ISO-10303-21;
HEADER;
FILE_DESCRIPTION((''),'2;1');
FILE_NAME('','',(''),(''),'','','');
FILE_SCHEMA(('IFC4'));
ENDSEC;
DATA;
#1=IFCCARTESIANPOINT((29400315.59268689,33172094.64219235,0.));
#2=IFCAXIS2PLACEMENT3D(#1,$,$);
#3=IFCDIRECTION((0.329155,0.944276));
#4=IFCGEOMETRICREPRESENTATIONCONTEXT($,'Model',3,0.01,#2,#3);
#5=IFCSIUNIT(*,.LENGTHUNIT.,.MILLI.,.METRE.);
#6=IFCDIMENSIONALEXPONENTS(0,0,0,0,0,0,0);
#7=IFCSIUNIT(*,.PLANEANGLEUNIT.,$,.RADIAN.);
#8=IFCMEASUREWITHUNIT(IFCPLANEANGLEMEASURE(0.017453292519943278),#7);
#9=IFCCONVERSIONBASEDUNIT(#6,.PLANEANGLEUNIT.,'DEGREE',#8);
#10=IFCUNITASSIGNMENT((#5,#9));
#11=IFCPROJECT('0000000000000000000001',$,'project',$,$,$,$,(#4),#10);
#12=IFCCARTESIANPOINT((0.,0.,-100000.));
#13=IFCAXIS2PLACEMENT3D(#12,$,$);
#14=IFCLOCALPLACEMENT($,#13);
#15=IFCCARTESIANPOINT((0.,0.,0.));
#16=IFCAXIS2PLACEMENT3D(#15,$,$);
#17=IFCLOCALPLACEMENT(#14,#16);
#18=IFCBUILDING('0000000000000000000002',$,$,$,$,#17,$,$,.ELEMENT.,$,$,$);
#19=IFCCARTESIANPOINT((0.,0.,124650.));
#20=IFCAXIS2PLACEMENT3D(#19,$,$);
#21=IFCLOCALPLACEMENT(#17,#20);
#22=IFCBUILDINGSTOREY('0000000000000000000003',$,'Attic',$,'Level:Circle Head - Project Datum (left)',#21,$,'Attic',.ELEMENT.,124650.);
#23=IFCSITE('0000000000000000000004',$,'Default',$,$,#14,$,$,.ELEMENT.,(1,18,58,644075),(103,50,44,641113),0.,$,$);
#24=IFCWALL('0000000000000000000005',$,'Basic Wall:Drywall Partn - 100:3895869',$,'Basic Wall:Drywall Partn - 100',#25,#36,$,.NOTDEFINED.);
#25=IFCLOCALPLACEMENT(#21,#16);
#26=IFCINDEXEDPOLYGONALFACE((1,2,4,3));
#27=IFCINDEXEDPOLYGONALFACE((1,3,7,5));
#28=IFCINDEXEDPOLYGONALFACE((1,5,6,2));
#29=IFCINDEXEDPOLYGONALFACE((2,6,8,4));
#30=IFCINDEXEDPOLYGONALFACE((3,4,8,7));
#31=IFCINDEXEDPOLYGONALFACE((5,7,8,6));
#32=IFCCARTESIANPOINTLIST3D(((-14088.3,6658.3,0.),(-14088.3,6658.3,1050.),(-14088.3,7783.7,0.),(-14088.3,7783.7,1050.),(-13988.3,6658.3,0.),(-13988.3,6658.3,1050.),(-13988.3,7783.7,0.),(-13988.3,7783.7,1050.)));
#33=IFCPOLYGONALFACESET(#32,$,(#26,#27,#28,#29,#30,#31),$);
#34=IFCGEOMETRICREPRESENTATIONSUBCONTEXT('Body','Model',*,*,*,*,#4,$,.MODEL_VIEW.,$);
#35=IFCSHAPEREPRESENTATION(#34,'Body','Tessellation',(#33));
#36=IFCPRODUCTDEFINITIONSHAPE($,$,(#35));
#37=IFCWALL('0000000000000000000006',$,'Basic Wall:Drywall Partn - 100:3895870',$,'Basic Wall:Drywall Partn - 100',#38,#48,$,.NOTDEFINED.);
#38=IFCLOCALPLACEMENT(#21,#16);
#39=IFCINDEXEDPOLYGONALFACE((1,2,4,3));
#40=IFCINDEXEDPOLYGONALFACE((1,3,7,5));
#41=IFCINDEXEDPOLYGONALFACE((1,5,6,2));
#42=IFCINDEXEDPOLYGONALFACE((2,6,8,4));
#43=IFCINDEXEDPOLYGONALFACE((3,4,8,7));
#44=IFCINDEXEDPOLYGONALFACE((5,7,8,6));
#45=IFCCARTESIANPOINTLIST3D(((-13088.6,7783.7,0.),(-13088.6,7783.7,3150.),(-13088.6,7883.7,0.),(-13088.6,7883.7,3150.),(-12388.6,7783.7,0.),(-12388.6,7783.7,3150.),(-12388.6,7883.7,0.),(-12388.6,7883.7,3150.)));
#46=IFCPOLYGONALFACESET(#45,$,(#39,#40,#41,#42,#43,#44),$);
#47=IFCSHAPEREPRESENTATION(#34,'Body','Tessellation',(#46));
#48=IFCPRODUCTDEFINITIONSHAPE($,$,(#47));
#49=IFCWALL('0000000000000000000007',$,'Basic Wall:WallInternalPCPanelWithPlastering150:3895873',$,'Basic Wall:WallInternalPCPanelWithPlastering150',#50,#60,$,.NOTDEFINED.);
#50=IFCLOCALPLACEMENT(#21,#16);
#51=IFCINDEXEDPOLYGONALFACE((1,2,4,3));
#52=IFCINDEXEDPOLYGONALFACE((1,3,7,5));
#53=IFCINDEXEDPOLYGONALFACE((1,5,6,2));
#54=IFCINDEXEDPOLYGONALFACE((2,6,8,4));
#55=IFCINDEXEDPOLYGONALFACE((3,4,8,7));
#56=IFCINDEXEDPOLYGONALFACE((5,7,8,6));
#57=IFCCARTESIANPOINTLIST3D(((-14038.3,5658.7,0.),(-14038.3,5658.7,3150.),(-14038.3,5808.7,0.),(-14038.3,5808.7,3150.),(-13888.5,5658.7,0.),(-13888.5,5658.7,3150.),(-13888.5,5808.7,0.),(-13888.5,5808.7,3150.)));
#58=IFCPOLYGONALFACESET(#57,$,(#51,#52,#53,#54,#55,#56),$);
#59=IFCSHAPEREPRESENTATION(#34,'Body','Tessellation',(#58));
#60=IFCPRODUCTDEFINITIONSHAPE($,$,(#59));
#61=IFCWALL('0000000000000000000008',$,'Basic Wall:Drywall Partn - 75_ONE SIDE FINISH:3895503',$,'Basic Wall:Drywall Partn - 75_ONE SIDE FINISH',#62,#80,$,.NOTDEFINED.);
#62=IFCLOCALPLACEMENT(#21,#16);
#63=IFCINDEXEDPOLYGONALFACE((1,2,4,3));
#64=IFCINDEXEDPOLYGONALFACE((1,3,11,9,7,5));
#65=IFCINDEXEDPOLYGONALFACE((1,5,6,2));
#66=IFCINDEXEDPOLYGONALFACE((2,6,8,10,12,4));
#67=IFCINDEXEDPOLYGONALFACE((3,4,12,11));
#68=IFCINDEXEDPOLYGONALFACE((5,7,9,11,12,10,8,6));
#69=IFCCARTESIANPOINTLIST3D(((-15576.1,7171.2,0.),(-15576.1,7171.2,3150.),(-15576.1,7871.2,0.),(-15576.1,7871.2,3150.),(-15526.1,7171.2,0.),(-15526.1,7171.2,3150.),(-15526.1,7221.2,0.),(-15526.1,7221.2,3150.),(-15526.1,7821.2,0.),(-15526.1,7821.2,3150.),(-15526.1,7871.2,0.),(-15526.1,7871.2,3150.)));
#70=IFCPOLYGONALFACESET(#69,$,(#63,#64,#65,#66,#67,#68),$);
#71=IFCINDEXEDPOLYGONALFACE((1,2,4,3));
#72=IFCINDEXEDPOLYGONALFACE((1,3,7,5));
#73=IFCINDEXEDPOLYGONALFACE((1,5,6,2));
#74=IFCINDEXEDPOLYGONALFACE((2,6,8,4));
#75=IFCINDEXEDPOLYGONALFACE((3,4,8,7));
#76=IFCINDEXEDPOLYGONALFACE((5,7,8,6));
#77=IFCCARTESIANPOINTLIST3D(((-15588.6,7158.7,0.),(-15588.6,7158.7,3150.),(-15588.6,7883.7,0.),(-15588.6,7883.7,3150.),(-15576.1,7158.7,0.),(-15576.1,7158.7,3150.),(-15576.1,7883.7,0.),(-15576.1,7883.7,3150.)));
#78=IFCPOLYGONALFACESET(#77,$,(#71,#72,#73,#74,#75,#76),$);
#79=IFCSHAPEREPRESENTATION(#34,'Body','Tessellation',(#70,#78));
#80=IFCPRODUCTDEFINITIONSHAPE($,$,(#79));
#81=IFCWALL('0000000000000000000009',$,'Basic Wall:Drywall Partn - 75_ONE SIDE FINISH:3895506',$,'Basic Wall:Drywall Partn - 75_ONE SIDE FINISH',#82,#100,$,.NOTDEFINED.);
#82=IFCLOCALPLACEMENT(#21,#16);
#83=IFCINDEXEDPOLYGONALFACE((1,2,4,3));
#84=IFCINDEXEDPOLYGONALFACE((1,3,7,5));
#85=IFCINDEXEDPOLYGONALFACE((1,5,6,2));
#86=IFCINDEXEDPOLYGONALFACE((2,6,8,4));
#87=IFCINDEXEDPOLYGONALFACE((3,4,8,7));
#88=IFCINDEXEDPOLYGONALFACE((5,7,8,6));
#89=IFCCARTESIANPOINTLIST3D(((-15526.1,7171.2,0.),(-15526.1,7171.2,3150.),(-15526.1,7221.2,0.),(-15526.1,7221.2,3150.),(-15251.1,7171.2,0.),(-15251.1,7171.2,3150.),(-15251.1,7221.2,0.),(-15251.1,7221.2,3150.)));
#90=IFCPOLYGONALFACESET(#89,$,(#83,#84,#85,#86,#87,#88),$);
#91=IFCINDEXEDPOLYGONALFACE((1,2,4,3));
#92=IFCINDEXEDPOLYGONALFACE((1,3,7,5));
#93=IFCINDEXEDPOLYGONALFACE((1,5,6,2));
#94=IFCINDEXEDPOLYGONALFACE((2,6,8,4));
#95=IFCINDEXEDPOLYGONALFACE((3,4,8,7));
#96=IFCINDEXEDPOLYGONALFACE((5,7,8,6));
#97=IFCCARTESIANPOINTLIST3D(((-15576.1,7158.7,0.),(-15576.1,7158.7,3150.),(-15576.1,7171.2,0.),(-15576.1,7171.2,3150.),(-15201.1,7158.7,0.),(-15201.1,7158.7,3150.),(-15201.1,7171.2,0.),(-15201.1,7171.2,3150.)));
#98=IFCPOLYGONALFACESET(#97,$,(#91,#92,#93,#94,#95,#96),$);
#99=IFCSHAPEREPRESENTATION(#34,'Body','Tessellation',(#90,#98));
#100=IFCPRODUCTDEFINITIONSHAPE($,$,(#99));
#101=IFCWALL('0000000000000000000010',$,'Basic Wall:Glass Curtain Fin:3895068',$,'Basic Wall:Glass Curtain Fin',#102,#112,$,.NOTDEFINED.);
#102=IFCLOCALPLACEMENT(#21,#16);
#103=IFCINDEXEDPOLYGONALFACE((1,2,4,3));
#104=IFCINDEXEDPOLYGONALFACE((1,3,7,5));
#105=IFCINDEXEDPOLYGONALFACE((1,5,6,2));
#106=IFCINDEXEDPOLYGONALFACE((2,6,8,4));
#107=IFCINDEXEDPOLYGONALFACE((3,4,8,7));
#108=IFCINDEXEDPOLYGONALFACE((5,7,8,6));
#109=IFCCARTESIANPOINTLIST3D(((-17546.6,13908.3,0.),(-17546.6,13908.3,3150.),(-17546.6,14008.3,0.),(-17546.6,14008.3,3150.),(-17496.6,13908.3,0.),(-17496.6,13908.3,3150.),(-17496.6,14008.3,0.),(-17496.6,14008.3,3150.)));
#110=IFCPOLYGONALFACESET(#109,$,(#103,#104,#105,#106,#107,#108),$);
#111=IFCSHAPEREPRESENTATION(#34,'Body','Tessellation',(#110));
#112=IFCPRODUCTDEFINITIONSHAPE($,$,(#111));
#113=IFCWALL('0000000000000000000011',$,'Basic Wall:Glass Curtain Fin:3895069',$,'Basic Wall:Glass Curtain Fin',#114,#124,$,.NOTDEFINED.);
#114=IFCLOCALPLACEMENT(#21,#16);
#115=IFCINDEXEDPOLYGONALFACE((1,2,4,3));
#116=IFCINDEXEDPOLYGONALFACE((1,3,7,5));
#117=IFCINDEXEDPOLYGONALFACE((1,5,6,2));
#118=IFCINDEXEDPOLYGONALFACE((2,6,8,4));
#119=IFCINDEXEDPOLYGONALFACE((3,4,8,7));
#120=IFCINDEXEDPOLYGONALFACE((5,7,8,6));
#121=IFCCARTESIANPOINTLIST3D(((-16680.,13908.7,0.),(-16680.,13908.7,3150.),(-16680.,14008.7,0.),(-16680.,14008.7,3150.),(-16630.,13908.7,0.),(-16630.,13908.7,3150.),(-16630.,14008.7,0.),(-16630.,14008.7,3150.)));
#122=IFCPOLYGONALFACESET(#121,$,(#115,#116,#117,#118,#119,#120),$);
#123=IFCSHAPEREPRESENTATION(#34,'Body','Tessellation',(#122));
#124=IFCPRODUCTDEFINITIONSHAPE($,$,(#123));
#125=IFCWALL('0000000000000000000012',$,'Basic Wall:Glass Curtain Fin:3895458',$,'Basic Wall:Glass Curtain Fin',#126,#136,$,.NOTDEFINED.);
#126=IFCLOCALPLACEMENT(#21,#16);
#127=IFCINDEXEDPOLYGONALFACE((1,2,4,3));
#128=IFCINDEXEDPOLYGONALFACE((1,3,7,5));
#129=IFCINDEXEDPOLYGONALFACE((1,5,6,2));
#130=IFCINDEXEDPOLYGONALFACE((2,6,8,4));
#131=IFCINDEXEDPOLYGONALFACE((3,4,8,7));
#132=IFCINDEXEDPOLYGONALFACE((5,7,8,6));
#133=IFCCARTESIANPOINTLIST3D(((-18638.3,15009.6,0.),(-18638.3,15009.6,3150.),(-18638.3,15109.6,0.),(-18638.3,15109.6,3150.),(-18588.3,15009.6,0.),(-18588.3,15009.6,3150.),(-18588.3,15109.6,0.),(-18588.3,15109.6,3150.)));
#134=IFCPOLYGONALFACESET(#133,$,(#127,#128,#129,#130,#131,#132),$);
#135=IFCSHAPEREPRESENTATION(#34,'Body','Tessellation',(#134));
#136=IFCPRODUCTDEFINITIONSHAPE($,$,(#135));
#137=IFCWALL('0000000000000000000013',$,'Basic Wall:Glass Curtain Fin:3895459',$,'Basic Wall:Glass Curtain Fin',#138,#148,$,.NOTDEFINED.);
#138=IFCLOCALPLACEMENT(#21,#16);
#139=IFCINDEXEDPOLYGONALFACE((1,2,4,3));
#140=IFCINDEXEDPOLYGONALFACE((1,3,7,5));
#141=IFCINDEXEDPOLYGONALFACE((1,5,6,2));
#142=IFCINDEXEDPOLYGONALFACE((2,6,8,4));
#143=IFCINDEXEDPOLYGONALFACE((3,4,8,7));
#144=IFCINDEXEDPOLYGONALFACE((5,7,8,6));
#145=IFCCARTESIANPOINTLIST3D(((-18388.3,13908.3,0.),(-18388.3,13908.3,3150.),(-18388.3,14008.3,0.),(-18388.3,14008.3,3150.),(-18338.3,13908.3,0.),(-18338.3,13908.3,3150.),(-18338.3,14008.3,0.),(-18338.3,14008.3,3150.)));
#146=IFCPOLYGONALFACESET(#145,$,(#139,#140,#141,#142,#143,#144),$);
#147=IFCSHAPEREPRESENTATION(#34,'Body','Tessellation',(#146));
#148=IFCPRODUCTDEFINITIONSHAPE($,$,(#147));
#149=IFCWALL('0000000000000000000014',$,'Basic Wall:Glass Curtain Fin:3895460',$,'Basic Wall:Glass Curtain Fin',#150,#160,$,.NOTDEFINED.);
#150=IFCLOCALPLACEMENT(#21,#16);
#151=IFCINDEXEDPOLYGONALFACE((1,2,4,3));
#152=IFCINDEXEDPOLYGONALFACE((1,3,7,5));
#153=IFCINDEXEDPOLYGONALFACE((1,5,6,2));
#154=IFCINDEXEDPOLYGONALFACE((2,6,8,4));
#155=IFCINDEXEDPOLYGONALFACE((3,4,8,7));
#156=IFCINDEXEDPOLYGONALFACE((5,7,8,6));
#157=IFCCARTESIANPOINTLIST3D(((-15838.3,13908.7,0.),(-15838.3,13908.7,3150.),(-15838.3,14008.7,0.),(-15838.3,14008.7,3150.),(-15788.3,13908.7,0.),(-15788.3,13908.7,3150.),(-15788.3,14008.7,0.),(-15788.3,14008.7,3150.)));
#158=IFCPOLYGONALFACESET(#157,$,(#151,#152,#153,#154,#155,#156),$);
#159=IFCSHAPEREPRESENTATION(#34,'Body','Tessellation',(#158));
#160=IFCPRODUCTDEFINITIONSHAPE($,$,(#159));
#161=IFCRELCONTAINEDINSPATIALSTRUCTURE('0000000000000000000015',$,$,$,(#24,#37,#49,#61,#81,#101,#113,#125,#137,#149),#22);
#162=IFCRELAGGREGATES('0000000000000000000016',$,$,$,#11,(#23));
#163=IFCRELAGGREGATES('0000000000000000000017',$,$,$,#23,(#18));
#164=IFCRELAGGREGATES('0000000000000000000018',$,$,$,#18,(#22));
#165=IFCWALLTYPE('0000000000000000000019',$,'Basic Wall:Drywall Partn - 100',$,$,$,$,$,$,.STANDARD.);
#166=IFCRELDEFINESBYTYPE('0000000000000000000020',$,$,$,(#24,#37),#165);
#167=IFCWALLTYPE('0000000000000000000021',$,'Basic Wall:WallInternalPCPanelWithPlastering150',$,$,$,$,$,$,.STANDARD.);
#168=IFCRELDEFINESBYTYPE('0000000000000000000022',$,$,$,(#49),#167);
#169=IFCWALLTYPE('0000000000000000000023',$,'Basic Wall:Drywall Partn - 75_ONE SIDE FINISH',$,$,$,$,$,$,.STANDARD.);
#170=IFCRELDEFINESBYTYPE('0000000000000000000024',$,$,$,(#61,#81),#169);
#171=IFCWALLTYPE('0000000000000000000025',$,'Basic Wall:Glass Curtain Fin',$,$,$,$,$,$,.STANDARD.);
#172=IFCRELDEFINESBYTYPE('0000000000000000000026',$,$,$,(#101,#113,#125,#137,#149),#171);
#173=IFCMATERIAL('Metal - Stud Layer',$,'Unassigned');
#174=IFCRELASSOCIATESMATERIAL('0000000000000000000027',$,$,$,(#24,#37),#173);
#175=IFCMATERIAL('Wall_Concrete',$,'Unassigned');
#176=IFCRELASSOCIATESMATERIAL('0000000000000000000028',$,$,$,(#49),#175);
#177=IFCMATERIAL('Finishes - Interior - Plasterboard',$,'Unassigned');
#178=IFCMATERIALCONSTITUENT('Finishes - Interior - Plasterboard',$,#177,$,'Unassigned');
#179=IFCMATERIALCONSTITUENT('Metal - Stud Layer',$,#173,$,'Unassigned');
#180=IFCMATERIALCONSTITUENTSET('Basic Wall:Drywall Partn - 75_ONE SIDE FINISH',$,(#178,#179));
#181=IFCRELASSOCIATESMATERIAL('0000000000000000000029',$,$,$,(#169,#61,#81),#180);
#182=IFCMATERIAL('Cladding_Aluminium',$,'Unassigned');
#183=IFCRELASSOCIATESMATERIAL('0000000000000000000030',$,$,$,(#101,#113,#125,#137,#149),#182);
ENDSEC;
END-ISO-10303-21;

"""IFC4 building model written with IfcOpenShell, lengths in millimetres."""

from ifc_helpers import new_model, entity, si_unit, converted_unit, direction, frame, origin, place, context, subcontext, project, spatial, indexed_curve, outline, extrude, material, constituent, constituent_set, type_object, element, save


model = new_model("IFC4")

# Units and contexts
model_context = context("Model", 3, precision=0.01, world=frame((29400315.59268689, 33172094.64219235, 0.0)), true_north=direction((0.329155, 0.944276)))
body_context = subcontext(model_context, "Body", "Model", "MODEL_VIEW")
ifc_project = project(units=[si_unit("LENGTHUNIT", "METRE", prefix="MILLI"), converted_unit("PLANEANGLEUNIT", "DEGREE", entity("IfcPlaneAngleMeasure", 0.017453292519943278), si_unit("PLANEANGLEUNIT", "RADIAN"), dimensions=[0, 0, 0, 0, 0, 0, 0])], contexts=[model_context])

# Site, building, storey
site_placement = place(None, frame((0.0, 0.0, -100000.0)))
site = spatial("IfcSite", under=ifc_project, at=site_placement, Name="Default", CompositionType="ELEMENT", RefLatitude=(1, 18, 58, 644075), RefLongitude=(103, 50, 44, 641113), RefElevation=0.0)
building_placement = place(site_placement, origin())
building = spatial("IfcBuilding", under=site, at=building_placement, CompositionType="ELEMENT")
storey_placement = place(building_placement, frame((0.0, 0.0, 124650.0)))
storey = spatial("IfcBuildingStorey", under=building, at=storey_placement, Name="Attic", ObjectType="Level:Circle Head - Project Datum (left)", LongName="Attic", CompositionType="ELEMENT", Elevation=124650.0)

# Walls
ifc_material_1 = material(Name="Metal - Stud Layer", Category="Unassigned")
wall_type_1 = type_object("IfcWallType", Name="Basic Wall:Drywall Partn - 100", PredefinedType="STANDARD")
wall_1_placement = place(storey_placement, frame((-14038.3, 7783.7, 0.0), z_axis=(0.0, 0.0, 1.0), x_axis=(0.0, -1.0, 0.0)))
element("IfcWall", 1, at=wall_1_placement, inside=storey, type_object=wall_type_1, material=ifc_material_1, Name="Basic Wall:Drywall Partn - 100:3895869", ObjectType="Basic Wall:Drywall Partn - 100", PredefinedType="NOTDEFINED", context=body_context, shape_type="SweptSolid", body=[
    extrude(outline(indexed_curve([(1125.4, 50.0), (0.0, 50.0), (0.0, -50.0), (1125.4, -50.0), (1125.4, 50.0)], self_intersect=False)), origin(), (0.0, 0.0, 1.0), 1050.0),
])
wall_2_placement = place(storey_placement, frame((-13088.6, 7833.7, 0.0)))
element("IfcWall", 2, at=wall_2_placement, inside=storey, type_object=wall_type_1, material=ifc_material_1, Name="Basic Wall:Drywall Partn - 100:3895870", ObjectType="Basic Wall:Drywall Partn - 100", PredefinedType="NOTDEFINED", context=body_context, shape_type="SweptSolid", body=[
    extrude(outline(indexed_curve([(700.0, 50.0), (0.0, 50.0), (0.0, -50.0), (700.0, -50.0), (700.0, 50.0)], self_intersect=False)), origin(), (0.0, 0.0, 1.0), 3150.0),
])
ifc_material_2 = material(Name="Wall_Concrete", Category="Unassigned")
wall_type_2 = type_object("IfcWallType", Name="Basic Wall:WallInternalPCPanelWithPlastering150", PredefinedType="STANDARD")
wall_3_placement = place(storey_placement, frame((-13888.5, 5733.7, 0.0), z_axis=(0.0, 0.0, 1.0), x_axis=(-1.0, 0.0, 0.0)))
element("IfcWall", 3, at=wall_3_placement, inside=storey, type_object=wall_type_2, material=ifc_material_2, Name="Basic Wall:WallInternalPCPanelWithPlastering150:3895873", ObjectType="Basic Wall:WallInternalPCPanelWithPlastering150", PredefinedType="NOTDEFINED", context=body_context, shape_type="SweptSolid", body=[
    extrude(outline(indexed_curve([(149.9, 75.0), (0.0, 75.0), (0.0, -75.0), (149.9, -75.0), (149.9, 75.0)], self_intersect=False)), origin(), (0.0, 0.0, 1.0), 3150.0),
])
ifc_material_3 = material(Name="Finishes - Interior - Plasterboard", Category="Unassigned")
ifc_constituent_1 = constituent(ifc_material_3, Name="Finishes - Interior - Plasterboard", Category="Unassigned")
ifc_constituent_2 = constituent(ifc_material_1, Name="Metal - Stud Layer", Category="Unassigned")
ifc_constituent_set = constituent_set(constituents=[ifc_constituent_1, ifc_constituent_2], Name="Basic Wall:Drywall Partn - 75_ONE SIDE FINISH")
wall_type_3 = type_object("IfcWallType", Name="Basic Wall:Drywall Partn - 75_ONE SIDE FINISH", PredefinedType="STANDARD", material=ifc_constituent_set)
wall_4_placement = place(storey_placement, frame((-15557.3, 7158.7, 0.0), z_axis=(0.0, 0.0, 1.0), x_axis=(0.0, 1.0, 0.0)))
element("IfcWall", 4, at=wall_4_placement, inside=storey, type_object=wall_type_3, material=ifc_constituent_set, Name="Basic Wall:Drywall Partn - 75_ONE SIDE FINISH:3895503", ObjectType="Basic Wall:Drywall Partn - 75_ONE SIDE FINISH", PredefinedType="NOTDEFINED", context=body_context, shape_type="SweptSolid", body=[
    extrude(outline(indexed_curve([(-300.0, -16.7), (300.0, -16.7), (350.0, -16.7), (350.0, 33.3), (-350.0, 33.3), (-350.0, -16.7), (-300.0, -16.7)], self_intersect=False)), frame((362.5, -14.6, 0.0)), (0.0, 0.0, 1.0), 3150.0),
    extrude(outline(indexed_curve([(-6.3, -362.5), (6.2, -362.5), (6.2, 362.5), (-6.3, 362.5), (-6.3, -362.5)], self_intersect=False)), frame((362.5, 25.0, 0.0), z_axis=(0.0, 0.0, 1.0), x_axis=(0.0, -1.0, 0.0)), (0.0, 0.0, 1.0), 3150.0),
])

# Walls
wall_5_placement = place(storey_placement, frame((-15526.1, 7189.9, 0.0)))
element("IfcWall", 5, at=wall_5_placement, inside=storey, type_object=wall_type_3, material=ifc_constituent_set, Name="Basic Wall:Drywall Partn - 75_ONE SIDE FINISH:3895506", ObjectType="Basic Wall:Drywall Partn - 75_ONE SIDE FINISH", PredefinedType="NOTDEFINED", context=body_context, shape_type="SweptSolid", body=[
    extrude(outline(indexed_curve([(-25.0, -137.5), (25.0, -137.5), (25.0, 137.5), (-25.0, 137.5), (-25.0, -137.5)], self_intersect=False)), frame((137.5, 6.3, 0.0), z_axis=(0.0, 0.0, 1.0), x_axis=(0.0, -1.0, 0.0)), (0.0, 0.0, 1.0), 3150.0),
    extrude(outline(indexed_curve([(-6.3, -187.5), (6.2, -187.5), (6.3, 187.5), (-6.2, 187.5), (-6.3, -187.5)], self_intersect=False)), frame((137.5, -25.0, 0.0), z_axis=(0.0, 0.0, 1.0), x_axis=(0.0, 1.0, 0.0)), (0.0, 0.0, 1.0), 3150.0),
])
ifc_material_4 = material(Name="Cladding_Aluminium", Category="Unassigned")
wall_type_4 = type_object("IfcWallType", Name="Basic Wall:Glass Curtain Fin", PredefinedType="STANDARD")
wall_6_placement = place(storey_placement, frame((-17521.6, 13908.3, 0.0), z_axis=(0.0, 0.0, 1.0), x_axis=(0.0, 1.0, 0.0)))
element("IfcWall", 6, at=wall_6_placement, inside=storey, type_object=wall_type_4, material=ifc_material_4, Name="Basic Wall:Glass Curtain Fin:3895068", ObjectType="Basic Wall:Glass Curtain Fin", PredefinedType="NOTDEFINED", context=body_context, shape_type="SweptSolid", body=[
    extrude(outline(indexed_curve([(100.0, 25.0), (0.0, 25.0), (0.0, -25.0), (100.0, -25.0), (100.0, 25.0)], self_intersect=False)), origin(), (0.0, 0.0, 1.0), 3150.0),
])
wall_7_placement = place(storey_placement, frame((-16655.0, 13908.7, 0.0), z_axis=(0.0, 0.0, 1.0), x_axis=(0.0, 1.0, 0.0)))
element("IfcWall", 7, at=wall_7_placement, inside=storey, type_object=wall_type_4, material=ifc_material_4, Name="Basic Wall:Glass Curtain Fin:3895069", ObjectType="Basic Wall:Glass Curtain Fin", PredefinedType="NOTDEFINED", context=body_context, shape_type="SweptSolid", body=[
    extrude(outline(indexed_curve([(100.0, 25.0), (0.0, 25.0), (0.0, -25.0), (100.0, -25.0), (100.0, 25.0)], self_intersect=False)), origin(), (0.0, 0.0, 1.0), 3150.0),
])
for number, where, z_axis, x_axis, name in (
    (8, (-18613.3, 15009.6, 0.0), (0.0, 0.0, 1.0), (0.0, 1.0, 0.0), "Basic Wall:Glass Curtain Fin:3895458"),
    (9, (-18363.3, 13908.3, 0.0), (0.0, 0.0, 1.0), (0.0, 1.0, 0.0), "Basic Wall:Glass Curtain Fin:3895459"),
):
    element("IfcWall", number, at=place(storey_placement, frame(where, z_axis=z_axis, x_axis=x_axis)), inside=storey, type_object=wall_type_4, material=ifc_material_4, Name=name, ObjectType="Basic Wall:Glass Curtain Fin", PredefinedType="NOTDEFINED", context=body_context, shape_type="SweptSolid", body=[
        extrude(outline(indexed_curve([(100.0, 25.0), (0.0, 25.0), (0.0, -25.0), (100.0, -25.0), (100.0, 25.0)], self_intersect=False)), origin(), (0.0, 0.0, 1.0), 3150.0),
    ])
wall_8_placement = place(storey_placement, frame((-15813.3, 13908.7, 0.0), z_axis=(0.0, 0.0, 1.0), x_axis=(0.0, 1.0, 0.0)))
element("IfcWall", 10, at=wall_8_placement, inside=storey, type_object=wall_type_4, material=ifc_material_4, Name="Basic Wall:Glass Curtain Fin:3895460", ObjectType="Basic Wall:Glass Curtain Fin", PredefinedType="NOTDEFINED", context=body_context, shape_type="SweptSolid", body=[
    extrude(outline(indexed_curve([(100.0, 25.0), (0.0, 25.0), (0.0, -25.0), (100.0, -25.0), (100.0, 25.0)], self_intersect=False)), origin(), (0.0, 0.0, 1.0), 3150.0),
])

save(model, "model.ifc")
